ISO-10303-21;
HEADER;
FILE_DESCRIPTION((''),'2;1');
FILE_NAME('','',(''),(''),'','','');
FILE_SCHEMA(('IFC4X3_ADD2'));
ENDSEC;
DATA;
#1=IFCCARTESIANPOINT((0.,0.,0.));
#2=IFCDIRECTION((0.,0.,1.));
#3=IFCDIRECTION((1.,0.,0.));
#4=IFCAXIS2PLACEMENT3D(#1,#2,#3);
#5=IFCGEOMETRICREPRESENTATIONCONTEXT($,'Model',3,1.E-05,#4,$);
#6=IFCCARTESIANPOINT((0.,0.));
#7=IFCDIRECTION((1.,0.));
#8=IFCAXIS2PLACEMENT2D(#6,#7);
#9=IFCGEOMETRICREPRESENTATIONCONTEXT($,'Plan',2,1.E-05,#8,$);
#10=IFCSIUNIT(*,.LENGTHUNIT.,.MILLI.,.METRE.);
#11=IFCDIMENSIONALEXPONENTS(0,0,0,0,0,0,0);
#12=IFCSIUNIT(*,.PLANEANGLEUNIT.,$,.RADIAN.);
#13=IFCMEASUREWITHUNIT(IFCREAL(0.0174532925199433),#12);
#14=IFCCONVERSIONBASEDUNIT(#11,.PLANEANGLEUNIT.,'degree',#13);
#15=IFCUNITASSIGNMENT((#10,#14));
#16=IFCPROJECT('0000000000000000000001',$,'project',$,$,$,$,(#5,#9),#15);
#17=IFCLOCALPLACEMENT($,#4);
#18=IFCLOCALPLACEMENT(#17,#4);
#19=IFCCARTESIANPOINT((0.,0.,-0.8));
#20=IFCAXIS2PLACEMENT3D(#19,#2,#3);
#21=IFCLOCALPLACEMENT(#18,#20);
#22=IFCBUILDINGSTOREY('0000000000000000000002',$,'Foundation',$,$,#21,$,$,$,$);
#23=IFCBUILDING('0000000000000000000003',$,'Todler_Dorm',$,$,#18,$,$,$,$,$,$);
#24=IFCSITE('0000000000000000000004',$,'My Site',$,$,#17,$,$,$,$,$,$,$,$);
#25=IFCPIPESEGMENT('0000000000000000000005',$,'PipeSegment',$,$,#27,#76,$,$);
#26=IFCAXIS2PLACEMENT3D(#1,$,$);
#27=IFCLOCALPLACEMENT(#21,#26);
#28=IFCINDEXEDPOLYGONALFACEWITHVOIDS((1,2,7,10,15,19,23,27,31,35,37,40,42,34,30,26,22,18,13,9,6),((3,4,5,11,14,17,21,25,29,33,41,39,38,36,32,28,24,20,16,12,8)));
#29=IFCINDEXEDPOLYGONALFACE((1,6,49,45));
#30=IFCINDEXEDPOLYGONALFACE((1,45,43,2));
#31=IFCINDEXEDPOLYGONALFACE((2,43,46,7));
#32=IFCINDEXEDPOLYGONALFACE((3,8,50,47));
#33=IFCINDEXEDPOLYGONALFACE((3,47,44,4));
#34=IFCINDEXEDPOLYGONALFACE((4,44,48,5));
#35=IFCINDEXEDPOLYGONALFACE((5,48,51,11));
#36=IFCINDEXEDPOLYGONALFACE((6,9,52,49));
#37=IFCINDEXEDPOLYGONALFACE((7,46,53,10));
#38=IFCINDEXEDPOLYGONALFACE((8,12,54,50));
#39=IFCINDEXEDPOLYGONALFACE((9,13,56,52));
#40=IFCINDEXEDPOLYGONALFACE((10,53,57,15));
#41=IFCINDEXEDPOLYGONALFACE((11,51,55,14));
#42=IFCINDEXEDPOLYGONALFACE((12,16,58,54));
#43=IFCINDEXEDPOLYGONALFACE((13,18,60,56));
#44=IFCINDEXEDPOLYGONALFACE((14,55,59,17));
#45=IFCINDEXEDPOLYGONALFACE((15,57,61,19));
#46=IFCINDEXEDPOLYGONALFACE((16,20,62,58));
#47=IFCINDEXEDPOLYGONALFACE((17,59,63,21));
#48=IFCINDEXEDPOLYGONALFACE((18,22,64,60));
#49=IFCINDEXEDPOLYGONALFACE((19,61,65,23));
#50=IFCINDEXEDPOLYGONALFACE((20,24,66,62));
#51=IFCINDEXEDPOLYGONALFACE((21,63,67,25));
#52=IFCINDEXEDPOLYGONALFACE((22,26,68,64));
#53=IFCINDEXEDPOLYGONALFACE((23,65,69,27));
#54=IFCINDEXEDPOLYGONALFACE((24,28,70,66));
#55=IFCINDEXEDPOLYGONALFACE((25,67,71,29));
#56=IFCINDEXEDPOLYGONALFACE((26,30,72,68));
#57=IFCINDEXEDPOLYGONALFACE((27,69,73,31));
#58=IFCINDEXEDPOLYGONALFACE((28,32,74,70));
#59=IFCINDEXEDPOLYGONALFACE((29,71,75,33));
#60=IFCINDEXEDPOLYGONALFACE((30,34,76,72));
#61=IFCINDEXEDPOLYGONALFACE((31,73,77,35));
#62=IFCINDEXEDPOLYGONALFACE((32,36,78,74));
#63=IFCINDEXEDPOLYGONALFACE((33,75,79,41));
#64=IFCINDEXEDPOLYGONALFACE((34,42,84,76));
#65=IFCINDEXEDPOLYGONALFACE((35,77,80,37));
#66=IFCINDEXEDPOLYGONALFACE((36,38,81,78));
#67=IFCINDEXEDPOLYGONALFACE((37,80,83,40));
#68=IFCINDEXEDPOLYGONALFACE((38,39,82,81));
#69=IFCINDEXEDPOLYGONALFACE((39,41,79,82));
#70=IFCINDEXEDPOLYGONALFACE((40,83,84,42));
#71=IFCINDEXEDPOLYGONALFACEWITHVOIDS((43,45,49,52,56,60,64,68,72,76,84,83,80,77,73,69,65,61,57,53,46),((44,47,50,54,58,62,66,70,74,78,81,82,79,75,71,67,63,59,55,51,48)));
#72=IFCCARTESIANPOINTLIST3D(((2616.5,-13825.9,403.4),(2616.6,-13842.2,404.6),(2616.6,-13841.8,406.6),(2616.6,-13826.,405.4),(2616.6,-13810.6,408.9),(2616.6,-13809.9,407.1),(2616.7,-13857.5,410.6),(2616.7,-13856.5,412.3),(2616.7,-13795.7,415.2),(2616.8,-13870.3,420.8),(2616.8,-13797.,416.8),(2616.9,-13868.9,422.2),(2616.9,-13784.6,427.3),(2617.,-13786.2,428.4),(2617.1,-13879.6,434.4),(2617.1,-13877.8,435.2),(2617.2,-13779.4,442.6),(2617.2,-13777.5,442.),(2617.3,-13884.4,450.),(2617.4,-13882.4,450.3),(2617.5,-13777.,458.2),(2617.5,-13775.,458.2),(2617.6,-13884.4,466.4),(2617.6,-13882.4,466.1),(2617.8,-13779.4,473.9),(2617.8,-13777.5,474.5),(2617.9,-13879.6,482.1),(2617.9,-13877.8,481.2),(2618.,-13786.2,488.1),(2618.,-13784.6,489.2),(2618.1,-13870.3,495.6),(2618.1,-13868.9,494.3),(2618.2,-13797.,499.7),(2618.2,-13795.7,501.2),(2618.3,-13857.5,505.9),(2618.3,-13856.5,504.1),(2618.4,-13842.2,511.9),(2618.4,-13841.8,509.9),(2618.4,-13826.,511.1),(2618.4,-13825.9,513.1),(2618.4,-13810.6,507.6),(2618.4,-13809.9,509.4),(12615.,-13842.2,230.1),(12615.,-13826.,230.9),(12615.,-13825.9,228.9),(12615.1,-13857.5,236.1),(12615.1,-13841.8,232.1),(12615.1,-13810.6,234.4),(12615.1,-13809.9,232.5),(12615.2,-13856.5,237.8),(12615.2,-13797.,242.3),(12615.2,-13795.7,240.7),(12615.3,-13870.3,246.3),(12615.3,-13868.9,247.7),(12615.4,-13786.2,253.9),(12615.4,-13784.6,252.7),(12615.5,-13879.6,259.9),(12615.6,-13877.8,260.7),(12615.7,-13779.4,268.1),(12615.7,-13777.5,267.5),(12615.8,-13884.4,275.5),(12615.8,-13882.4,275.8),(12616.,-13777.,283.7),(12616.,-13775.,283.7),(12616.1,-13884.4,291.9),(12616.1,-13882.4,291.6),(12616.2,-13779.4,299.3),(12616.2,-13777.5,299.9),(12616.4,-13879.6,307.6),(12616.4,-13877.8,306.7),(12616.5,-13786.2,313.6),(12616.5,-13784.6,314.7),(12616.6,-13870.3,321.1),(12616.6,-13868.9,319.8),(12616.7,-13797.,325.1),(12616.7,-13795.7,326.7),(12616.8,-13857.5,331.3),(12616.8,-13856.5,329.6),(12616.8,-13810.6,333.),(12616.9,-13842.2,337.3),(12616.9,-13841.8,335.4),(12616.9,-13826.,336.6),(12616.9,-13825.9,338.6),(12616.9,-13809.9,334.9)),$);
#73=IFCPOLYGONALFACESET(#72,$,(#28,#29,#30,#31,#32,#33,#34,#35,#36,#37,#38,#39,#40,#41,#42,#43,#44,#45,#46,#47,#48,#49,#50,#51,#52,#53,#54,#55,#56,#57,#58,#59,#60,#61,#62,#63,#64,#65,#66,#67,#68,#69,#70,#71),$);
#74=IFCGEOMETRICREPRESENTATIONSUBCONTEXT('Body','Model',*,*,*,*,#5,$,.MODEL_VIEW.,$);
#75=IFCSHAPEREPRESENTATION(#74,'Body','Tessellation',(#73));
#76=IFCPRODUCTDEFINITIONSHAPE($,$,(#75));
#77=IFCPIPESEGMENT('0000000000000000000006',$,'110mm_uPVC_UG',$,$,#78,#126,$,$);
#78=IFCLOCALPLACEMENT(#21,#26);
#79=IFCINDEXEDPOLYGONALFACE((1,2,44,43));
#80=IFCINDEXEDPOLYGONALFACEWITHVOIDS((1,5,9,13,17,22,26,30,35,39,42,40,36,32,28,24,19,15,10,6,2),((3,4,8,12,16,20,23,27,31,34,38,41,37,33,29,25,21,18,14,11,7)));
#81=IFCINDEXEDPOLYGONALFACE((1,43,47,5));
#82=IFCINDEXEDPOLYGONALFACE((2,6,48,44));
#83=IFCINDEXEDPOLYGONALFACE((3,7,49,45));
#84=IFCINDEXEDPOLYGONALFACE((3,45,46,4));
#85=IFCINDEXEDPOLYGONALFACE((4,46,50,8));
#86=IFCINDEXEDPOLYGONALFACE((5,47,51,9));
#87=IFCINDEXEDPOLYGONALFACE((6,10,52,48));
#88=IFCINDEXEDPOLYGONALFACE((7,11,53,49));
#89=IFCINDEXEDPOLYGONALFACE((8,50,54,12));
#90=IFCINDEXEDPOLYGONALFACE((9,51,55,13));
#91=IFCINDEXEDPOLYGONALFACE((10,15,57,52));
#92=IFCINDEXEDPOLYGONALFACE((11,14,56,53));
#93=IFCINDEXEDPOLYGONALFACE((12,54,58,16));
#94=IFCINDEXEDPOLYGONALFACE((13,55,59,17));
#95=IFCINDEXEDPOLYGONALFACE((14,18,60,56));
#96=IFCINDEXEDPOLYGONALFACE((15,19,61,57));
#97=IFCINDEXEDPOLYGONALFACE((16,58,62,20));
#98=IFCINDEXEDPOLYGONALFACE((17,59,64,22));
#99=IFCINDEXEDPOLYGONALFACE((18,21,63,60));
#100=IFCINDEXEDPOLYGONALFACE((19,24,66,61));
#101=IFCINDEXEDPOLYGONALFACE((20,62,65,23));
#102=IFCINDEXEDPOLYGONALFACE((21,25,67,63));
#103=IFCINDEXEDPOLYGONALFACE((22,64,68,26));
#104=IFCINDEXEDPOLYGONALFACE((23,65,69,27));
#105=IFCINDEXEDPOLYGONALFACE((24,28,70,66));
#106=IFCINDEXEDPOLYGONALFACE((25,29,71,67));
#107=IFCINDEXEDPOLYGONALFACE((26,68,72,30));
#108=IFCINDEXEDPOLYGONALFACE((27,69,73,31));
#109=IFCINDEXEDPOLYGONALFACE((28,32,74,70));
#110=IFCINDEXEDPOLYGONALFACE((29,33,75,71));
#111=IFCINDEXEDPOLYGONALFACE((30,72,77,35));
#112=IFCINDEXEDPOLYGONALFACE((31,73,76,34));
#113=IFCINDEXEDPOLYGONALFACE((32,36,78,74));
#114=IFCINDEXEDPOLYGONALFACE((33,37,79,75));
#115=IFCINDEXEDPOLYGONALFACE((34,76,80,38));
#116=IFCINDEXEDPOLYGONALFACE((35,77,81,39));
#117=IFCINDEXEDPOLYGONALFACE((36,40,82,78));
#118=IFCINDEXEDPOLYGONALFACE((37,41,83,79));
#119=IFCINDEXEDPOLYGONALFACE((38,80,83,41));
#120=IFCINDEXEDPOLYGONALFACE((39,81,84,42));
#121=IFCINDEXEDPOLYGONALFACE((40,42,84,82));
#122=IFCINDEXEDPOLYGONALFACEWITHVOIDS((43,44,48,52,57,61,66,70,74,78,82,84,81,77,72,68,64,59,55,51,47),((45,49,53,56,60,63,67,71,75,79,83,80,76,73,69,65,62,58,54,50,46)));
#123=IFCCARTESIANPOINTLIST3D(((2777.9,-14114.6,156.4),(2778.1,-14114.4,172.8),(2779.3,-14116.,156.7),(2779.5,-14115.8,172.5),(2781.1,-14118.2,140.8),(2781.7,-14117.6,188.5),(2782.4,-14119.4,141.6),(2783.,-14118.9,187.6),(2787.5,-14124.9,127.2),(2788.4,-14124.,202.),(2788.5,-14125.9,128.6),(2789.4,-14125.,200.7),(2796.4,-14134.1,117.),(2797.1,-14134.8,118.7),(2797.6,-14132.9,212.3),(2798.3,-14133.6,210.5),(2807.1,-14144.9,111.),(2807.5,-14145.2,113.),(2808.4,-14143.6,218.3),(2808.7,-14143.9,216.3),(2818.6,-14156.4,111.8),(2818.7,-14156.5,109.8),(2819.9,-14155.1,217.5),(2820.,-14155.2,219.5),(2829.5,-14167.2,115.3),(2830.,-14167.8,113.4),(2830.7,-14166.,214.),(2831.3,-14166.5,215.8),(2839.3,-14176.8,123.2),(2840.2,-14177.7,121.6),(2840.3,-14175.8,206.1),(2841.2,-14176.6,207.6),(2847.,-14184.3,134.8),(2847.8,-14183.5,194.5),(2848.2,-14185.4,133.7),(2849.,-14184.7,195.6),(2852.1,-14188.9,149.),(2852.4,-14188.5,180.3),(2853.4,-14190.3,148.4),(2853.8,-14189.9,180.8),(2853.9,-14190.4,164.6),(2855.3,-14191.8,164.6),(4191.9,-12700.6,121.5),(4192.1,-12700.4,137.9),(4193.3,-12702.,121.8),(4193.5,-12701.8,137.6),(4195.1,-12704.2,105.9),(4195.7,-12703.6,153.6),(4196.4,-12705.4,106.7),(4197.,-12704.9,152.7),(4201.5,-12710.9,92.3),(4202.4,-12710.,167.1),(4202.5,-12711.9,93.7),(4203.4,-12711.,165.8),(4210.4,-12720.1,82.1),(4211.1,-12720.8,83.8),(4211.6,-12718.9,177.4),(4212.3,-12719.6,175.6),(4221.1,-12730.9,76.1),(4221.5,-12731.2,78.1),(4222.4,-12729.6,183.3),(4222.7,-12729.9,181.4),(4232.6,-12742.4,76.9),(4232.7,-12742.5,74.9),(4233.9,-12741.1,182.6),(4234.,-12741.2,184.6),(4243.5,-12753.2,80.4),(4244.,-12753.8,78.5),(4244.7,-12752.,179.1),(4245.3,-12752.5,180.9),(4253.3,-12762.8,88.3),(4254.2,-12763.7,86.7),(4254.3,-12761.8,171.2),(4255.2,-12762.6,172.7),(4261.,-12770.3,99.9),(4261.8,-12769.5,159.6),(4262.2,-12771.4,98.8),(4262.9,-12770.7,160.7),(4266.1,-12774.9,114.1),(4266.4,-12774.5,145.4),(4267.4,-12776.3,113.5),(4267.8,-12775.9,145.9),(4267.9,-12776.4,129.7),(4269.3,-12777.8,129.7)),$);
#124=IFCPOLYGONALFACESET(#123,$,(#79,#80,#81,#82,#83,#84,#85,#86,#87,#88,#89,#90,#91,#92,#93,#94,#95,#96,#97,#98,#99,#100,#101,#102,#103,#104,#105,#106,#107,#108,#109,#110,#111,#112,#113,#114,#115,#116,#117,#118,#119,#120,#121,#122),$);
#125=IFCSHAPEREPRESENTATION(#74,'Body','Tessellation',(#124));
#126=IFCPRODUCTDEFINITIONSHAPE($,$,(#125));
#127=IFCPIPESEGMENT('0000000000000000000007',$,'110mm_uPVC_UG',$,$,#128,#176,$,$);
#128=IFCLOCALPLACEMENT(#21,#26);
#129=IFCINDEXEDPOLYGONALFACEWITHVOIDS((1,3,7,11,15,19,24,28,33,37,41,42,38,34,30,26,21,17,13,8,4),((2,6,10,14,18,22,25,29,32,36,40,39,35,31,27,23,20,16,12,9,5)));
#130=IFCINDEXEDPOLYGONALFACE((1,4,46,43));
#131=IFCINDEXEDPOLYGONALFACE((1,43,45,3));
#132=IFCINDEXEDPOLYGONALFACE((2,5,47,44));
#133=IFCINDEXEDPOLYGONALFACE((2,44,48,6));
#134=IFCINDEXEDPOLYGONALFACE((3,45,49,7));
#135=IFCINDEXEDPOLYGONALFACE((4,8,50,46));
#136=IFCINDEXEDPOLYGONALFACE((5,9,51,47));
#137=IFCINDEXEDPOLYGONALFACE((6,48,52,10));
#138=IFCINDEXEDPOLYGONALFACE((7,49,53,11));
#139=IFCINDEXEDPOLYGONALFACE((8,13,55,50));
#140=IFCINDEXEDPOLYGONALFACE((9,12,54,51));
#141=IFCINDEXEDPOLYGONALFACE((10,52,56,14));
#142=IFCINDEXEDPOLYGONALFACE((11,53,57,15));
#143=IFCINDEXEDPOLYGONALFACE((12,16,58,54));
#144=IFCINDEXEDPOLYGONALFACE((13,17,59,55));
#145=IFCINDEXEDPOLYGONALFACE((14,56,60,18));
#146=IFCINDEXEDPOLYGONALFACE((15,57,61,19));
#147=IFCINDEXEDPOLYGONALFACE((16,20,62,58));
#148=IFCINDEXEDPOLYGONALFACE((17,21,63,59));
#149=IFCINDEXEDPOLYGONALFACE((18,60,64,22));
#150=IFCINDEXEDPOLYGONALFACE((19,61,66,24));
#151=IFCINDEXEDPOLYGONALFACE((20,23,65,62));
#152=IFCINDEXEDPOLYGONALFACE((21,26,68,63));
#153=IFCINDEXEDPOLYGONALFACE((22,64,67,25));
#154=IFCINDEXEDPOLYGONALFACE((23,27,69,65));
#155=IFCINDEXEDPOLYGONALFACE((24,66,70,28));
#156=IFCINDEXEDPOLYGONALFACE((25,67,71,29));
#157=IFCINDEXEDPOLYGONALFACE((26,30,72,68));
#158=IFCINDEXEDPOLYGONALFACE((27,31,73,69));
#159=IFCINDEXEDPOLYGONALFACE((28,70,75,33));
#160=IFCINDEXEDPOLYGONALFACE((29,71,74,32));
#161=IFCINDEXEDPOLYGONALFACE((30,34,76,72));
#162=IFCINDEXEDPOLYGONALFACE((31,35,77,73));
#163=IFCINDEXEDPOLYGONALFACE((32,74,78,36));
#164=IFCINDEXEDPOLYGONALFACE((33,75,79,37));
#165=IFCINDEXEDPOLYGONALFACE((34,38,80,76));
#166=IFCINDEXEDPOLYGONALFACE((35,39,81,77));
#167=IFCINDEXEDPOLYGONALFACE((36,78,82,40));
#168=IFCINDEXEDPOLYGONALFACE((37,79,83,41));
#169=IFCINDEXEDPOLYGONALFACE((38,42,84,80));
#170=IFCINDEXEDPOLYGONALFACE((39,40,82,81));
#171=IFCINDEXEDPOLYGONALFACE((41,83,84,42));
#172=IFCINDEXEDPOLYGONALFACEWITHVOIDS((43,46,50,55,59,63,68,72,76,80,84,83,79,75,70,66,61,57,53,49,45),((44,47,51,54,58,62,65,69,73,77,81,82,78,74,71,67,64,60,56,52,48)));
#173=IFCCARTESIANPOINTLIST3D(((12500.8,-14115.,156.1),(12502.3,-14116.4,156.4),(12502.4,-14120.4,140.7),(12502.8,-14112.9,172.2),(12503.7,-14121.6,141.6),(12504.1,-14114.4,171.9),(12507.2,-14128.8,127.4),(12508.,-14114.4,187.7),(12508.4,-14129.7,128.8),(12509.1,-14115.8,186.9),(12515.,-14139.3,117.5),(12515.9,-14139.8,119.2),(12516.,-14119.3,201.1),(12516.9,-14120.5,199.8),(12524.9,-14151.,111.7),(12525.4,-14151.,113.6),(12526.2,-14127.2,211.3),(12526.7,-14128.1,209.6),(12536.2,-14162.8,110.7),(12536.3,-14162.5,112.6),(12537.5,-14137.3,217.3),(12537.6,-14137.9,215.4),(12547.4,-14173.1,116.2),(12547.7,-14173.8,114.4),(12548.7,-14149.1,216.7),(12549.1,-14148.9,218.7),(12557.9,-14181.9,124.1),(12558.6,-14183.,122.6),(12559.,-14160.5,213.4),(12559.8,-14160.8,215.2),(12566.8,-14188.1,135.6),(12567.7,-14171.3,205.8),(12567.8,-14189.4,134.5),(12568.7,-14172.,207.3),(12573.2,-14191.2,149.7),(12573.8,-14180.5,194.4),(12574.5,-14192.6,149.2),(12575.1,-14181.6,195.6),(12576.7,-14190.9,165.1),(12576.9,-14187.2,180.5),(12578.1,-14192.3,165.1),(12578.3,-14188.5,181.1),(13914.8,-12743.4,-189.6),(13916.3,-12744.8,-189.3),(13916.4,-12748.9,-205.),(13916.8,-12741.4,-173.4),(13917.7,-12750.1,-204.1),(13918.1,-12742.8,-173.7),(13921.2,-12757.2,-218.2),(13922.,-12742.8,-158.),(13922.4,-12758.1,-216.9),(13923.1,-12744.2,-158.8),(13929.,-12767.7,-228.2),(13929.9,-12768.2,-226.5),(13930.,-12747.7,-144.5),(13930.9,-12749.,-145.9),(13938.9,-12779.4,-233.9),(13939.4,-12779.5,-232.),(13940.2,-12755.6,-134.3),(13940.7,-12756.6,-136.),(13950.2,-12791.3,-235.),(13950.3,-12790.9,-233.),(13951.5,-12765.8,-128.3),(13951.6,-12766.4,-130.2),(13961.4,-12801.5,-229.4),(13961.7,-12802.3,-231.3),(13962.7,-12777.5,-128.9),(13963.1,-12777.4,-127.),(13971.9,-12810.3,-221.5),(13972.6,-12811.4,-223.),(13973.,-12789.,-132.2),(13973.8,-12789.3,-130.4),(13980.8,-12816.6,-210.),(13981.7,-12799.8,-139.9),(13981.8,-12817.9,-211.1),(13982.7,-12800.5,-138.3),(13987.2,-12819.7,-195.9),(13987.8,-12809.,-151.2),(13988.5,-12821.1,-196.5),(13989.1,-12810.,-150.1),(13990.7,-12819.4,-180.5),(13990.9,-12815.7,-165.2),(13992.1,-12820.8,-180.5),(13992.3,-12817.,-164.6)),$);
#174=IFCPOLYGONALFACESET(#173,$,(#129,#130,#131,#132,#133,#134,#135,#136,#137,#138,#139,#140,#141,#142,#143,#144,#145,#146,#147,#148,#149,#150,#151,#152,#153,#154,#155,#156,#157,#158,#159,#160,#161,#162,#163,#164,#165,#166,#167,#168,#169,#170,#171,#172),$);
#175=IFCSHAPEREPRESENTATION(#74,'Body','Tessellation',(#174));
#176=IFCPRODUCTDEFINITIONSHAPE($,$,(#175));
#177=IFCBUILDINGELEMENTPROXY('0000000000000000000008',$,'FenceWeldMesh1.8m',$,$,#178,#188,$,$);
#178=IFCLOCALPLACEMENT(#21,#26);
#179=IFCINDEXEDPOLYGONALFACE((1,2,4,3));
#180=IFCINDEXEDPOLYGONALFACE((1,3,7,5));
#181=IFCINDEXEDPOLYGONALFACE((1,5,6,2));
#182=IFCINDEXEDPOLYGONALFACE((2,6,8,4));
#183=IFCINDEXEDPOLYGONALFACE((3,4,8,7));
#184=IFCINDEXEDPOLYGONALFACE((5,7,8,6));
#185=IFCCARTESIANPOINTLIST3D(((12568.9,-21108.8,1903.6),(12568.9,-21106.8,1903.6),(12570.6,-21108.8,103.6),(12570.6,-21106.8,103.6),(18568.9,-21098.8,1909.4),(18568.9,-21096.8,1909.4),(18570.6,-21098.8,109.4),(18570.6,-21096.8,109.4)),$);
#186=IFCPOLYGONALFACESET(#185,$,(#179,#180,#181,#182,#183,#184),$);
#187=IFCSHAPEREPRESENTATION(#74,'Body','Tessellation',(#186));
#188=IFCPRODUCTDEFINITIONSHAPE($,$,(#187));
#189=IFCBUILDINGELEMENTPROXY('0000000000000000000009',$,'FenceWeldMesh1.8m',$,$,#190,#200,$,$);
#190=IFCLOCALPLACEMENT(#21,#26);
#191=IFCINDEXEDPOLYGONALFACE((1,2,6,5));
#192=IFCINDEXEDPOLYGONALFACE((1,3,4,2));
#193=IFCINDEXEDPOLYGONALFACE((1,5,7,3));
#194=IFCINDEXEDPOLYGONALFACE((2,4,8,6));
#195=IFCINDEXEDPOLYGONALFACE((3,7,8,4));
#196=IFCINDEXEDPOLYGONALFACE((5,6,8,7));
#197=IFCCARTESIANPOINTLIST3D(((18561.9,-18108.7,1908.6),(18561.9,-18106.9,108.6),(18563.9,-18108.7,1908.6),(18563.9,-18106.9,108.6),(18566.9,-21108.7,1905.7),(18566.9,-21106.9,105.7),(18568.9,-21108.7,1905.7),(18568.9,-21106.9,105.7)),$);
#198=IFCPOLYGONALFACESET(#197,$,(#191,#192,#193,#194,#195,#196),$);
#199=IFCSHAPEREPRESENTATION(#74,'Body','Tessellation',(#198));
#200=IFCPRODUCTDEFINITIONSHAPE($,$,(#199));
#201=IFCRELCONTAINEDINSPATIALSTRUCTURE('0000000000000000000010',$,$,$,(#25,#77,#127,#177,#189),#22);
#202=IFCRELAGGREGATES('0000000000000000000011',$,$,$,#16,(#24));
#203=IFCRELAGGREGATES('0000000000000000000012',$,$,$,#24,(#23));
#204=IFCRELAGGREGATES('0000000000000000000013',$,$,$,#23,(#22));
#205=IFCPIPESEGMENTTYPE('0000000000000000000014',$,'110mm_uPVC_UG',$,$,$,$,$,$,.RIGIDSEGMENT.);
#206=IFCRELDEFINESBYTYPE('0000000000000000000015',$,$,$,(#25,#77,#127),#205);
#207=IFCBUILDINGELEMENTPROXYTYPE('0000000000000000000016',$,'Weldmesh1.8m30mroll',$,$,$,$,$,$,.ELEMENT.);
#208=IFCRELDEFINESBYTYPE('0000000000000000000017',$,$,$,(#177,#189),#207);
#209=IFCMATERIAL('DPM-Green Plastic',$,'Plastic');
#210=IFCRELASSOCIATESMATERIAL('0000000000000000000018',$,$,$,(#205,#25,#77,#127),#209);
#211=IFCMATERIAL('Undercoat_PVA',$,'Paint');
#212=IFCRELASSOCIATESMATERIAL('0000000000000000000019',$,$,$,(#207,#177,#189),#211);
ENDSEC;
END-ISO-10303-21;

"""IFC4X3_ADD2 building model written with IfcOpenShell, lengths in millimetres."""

from ifc_helpers import new_model, entity, si_unit, converted_unit, frame, origin_with_axes, origin_2d_with_axis, place, context, subcontext, project, spatial, rectangle, hollow_circle, extrude, material, material_profile, profile_set, profile_usage, type_object, element, save


model = new_model("IFC4X3_ADD2")

# Units and contexts
model_context = context("Model", 3, precision=1e-05, world=origin_with_axes())
plan_context = context("Plan", 2, precision=1e-05, world=origin_2d_with_axis())
body_context = subcontext(model_context, "Body", "Model", "MODEL_VIEW")
ifc_project = project(units=[si_unit("LENGTHUNIT", "METRE", prefix="MILLI"), converted_unit("PLANEANGLEUNIT", "degree", entity("IfcReal", 0.0174532925199433), si_unit("PLANEANGLEUNIT", "RADIAN"), dimensions=[0, 0, 0, 0, 0, 0, 0])], contexts=[model_context, plan_context])

# Site, building, storey
site_placement = place(None, origin_with_axes())
site = spatial("IfcSite", under=ifc_project, at=site_placement, Name="My Site")
building_placement = place(site_placement, origin_with_axes())
building = spatial("IfcBuilding", under=site, at=building_placement, Name="Todler_Dorm")
storey_placement = place(building_placement, frame((0.0, 0.0, -0.8), z_axis=(0.0, 0.0, 1.0), x_axis=(1.0, 0.0, 0.0)))
storey = spatial("IfcBuildingStorey", under=building, at=storey_placement, Name="Foundation")

# Shared definitions
ifc_material_1 = material(Name="Undercoat_PVA", Category="Paint")

# Pipe segments
ifc_material_2 = material(Name="DPM-Green Plastic", Category="Plastic")
ifc_material_profile_1 = material_profile(ifc_material_2, hollow_circle(Radius=55.0, WallThickness=2.0))
ifc_profile_set_1 = profile_set([ifc_material_profile_1])
ifc_profile_usage_1 = profile_usage(ifc_profile_set_1, cardinal=5)
pipe_segment_type = type_object("IfcPipeSegmentType", Name="110mm_uPVC_UG", PredefinedType="RIGIDSEGMENT", material=ifc_profile_set_1)
pipe_segment_1_placement = place(storey_placement, frame((2617.5, -13830.0, 458.2), z_axis=(0.999848, 0.0, -0.017452), x_axis=(0.0, 1.0, 0.0)))
element("IfcPipeSegment", 1, at=pipe_segment_1_placement, inside=storey, type_object=pipe_segment_type, material=ifc_profile_usage_1, Name="PipeSegment", context=body_context, shape_type="SweptSolid", body=[
    extrude(hollow_circle(Radius=55.0, WallThickness=2.0), origin_with_axes(), (0.0, 0.0, 1.0), 10000.0),
])
ifc_profile_usage_2 = profile_usage(ifc_profile_set_1, cardinal=5)
pipe_segment_2_placement = place(storey_placement, frame((4230.4, -12738.9, 129.7), z_axis=(-0.706999, -0.706999, 0.017452), x_axis=(0.707107, -0.707107, 0.0)))
element("IfcPipeSegment", 2, at=pipe_segment_2_placement, inside=storey, type_object=pipe_segment_type, material=ifc_profile_usage_2, Name="110mm_uPVC_UG", context=body_context, shape_type="SweptSolid", body=[
    extrude(hollow_circle(Radius=55.0, WallThickness=2.0), origin_with_axes(), (0.0, 0.0, 1.0), 2000.0),
])
ifc_profile_usage_3 = profile_usage(ifc_profile_set_1, cardinal=5)
pipe_segment_3_placement = place(storey_placement, frame((12539.7, -14152.9, 164.6), z_axis=(0.706999, 0.685772, -0.172825), x_axis=(-0.707107, 0.689724, -0.155826)))
element("IfcPipeSegment", 3, at=pipe_segment_3_placement, inside=storey, type_object=pipe_segment_type, material=ifc_profile_usage_3, Name="110mm_uPVC_UG", context=body_context, shape_type="SweptSolid", body=[
    extrude(hollow_circle(Radius=55.0, WallThickness=2.0), origin_with_axes(), (0.0, 0.0, 1.0), 2000.0),
])

# Building element proxies
ifc_material_profile_2 = material_profile(ifc_material_1, rectangle(XDim=1800.0, YDim=2.0))
ifc_profile_set_2 = profile_set([ifc_material_profile_2])
ifc_profile_usage_4 = profile_usage(ifc_profile_set_2, cardinal=5)
building_element_proxy_type = type_object("IfcBuildingElementProxyType", Name="Weldmesh1.8m30mroll", PredefinedType="ELEMENT", material=ifc_profile_set_2)
proxy_1_placement = place(storey_placement, frame((12569.8, -21107.8, 1003.6), z_axis=(0.999998, 0.001668, 0.000974), x_axis=(-0.000974, 0.0, 1.0)))
element("IfcBuildingElementProxy", 4, at=proxy_1_placement, inside=storey, type_object=building_element_proxy_type, material=ifc_profile_usage_4, Name="FenceWeldMesh1.8m", context=body_context, shape_type="SweptSolid", body=[
    extrude(rectangle(XDim=1800.0, YDim=2.0), origin_with_axes(), (0.0, 0.0, 1.0), 6000.0),
])
ifc_profile_usage_5 = profile_usage(ifc_profile_set_2, cardinal=5)
proxy_2_placement = place(storey_placement, frame((18567.9, -21107.8, 1005.7), z_axis=(-0.001669, 0.999998, 0.000974), x_axis=(0.0, -0.000974, 1.0)))
element("IfcBuildingElementProxy", 5, at=proxy_2_placement, inside=storey, type_object=building_element_proxy_type, material=ifc_profile_usage_5, Name="FenceWeldMesh1.8m", context=body_context, shape_type="SweptSolid", body=[
    extrude(rectangle(XDim=1800.0, YDim=2.0), origin_with_axes(), (0.0, 0.0, 1.0), 3000.0),
])

save(model, "model.ifc")
